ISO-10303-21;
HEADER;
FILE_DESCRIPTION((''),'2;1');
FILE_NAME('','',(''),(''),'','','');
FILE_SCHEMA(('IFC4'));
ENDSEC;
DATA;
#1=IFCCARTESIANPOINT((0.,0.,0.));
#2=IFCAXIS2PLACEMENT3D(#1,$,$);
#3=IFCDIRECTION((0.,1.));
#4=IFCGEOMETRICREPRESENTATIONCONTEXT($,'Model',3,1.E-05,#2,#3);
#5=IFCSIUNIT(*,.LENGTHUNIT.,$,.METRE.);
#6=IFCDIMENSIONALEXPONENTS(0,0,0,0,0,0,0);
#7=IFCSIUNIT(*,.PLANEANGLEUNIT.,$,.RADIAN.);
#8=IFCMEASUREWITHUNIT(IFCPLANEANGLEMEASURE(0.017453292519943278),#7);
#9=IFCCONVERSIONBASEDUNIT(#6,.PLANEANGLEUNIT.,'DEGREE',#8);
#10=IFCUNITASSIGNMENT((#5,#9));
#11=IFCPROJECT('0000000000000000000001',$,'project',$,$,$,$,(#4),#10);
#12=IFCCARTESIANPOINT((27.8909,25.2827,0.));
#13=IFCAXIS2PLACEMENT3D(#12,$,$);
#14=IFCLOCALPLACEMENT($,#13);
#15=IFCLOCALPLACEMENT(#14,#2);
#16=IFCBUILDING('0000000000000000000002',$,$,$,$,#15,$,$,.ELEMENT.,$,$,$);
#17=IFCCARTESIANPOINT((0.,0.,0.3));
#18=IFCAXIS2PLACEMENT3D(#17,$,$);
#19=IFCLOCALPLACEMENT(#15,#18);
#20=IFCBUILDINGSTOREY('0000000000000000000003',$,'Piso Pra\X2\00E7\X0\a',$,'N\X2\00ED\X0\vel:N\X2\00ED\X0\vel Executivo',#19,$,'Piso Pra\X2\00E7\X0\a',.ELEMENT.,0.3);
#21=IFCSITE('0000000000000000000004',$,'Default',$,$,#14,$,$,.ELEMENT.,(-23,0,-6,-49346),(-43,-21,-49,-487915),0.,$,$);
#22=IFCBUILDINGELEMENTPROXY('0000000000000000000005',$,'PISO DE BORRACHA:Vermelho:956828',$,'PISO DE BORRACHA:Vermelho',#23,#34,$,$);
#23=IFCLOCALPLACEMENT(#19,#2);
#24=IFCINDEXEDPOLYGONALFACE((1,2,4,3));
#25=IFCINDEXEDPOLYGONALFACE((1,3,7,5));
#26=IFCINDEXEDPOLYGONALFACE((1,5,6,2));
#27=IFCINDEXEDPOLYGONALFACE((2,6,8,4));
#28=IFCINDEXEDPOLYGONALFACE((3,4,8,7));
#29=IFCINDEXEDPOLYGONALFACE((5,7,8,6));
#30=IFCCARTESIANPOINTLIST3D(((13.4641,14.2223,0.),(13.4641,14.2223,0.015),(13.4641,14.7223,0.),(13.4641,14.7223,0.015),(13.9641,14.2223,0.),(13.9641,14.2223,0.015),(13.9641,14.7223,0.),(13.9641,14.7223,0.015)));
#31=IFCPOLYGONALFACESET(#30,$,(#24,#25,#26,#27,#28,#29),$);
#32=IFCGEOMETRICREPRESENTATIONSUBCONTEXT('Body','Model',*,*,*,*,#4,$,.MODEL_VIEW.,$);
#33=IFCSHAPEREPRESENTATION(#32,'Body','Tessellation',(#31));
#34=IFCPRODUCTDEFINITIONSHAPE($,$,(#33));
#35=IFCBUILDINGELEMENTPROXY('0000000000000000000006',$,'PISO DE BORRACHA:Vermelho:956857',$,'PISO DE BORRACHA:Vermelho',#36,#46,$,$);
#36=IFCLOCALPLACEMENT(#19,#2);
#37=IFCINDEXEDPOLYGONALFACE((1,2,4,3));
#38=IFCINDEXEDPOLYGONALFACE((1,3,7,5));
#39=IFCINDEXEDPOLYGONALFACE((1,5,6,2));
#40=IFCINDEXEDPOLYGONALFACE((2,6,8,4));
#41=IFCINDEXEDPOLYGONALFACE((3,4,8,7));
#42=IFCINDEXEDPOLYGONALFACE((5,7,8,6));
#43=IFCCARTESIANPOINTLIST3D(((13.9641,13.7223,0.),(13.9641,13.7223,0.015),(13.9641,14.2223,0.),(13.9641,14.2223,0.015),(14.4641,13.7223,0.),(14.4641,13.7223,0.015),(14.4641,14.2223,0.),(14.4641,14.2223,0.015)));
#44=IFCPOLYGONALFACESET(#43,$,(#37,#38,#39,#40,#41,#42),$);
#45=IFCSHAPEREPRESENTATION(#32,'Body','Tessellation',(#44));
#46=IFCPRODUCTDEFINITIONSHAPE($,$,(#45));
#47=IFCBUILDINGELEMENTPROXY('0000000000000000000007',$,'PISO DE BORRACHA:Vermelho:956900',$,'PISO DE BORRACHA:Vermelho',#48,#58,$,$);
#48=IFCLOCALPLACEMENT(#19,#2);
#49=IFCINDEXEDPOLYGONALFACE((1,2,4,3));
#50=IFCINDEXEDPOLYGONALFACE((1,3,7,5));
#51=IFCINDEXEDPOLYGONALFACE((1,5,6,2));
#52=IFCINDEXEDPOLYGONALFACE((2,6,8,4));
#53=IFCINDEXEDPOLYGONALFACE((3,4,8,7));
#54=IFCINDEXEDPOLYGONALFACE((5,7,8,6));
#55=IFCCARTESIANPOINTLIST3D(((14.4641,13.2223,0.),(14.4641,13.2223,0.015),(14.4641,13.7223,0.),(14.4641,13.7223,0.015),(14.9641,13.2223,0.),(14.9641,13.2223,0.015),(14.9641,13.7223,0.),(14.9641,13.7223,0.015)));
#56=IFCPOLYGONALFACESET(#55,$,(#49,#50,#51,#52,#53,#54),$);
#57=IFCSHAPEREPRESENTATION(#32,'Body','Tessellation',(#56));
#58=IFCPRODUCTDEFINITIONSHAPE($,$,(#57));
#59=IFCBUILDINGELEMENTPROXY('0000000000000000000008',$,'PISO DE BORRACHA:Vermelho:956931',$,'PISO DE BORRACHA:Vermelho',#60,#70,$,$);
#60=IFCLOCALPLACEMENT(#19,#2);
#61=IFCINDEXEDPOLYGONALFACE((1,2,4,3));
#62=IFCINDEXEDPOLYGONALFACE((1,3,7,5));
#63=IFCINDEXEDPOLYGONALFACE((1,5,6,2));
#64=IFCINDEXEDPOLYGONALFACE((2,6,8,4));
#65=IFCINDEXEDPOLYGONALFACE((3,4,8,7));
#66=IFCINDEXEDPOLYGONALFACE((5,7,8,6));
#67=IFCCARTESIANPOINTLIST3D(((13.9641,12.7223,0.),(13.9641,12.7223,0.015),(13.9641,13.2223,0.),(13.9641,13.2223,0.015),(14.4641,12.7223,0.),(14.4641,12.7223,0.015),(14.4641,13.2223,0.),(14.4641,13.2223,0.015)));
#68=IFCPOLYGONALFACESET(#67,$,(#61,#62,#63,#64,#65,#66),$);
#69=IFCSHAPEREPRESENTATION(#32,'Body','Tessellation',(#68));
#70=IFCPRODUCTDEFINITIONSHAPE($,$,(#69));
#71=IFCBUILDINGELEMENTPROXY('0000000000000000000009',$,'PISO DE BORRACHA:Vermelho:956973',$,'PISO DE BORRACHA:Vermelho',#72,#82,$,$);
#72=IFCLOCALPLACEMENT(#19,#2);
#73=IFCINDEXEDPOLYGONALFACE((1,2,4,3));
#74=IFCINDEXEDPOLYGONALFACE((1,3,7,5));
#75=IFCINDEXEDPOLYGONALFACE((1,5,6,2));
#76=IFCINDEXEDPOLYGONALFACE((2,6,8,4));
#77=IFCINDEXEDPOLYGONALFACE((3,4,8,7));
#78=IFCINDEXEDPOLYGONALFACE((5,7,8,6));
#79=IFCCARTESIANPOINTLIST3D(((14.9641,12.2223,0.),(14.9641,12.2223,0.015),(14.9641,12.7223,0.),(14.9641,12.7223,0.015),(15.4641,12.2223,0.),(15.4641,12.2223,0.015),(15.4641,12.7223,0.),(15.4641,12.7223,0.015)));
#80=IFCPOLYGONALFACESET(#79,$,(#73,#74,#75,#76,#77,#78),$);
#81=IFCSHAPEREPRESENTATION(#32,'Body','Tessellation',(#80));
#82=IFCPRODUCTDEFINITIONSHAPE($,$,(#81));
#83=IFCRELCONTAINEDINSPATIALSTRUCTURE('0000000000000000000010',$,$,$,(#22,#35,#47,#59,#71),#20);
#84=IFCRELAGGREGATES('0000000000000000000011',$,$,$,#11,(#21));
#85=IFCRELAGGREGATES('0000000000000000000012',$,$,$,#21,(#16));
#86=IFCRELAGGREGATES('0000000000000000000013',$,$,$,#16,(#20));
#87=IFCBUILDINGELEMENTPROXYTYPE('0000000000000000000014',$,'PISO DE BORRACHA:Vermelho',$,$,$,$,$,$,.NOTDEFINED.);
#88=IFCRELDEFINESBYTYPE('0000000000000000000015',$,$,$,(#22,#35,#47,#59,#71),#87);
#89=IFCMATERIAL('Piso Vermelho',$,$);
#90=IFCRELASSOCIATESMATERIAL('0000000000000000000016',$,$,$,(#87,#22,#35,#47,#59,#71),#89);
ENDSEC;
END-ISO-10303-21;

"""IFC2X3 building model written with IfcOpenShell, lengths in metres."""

from ifc_helpers import new_model, entity, si_unit, converted_unit, direction, frame, origin, origin_2d_with_axis, place, context, subcontext, project, spatial, rectangle, extrude, source, transform, mapped, material, type_object, type_shapes, element, save


model = new_model("IFC2X3")

# Units and contexts
model_context = context("Model", 3, precision=1e-05, world=origin(), true_north=direction((0.0, 1.0)))
body_context = subcontext(model_context, "Body", "Model", "MODEL_VIEW")
ifc_project = project(units=[si_unit("LENGTHUNIT", "METRE"), converted_unit("PLANEANGLEUNIT", "DEGREE", entity("IfcPlaneAngleMeasure", 0.017453292519943278), si_unit("PLANEANGLEUNIT", "RADIAN"), dimensions=[0, 0, 0, 0, 0, 0, 0])], contexts=[model_context])

# Site, building, storey
site_placement = place(None, frame((27.8909, 25.2827, 0.0)))
site = spatial("IfcSite", under=ifc_project, at=site_placement, Name="Default", CompositionType="ELEMENT", RefLatitude=(-23, 0, -6, -49346), RefLongitude=(-43, -21, -49, -487915), RefElevation=0.0)
building_placement = place(site_placement, origin())
building = spatial("IfcBuilding", under=site, at=building_placement, CompositionType="ELEMENT")
storey_placement = place(building_placement, frame((0.0, 0.0, 0.3)))
storey = spatial("IfcBuildingStorey", under=building, at=storey_placement, Name="Piso Praça", ObjectType="Nível:Nível Executivo", LongName="Piso Praça", CompositionType="ELEMENT", Elevation=0.3)

# Building element proxies
ifc_material_1 = material(Name="Piso Vermelho")
building_element_proxy_type_1 = type_object("IfcBuildingElementProxyType", Name="PISO DE BORRACHA:Vermelho", PredefinedType="NOTDEFINED", material=ifc_material_1)
shared_shape_1 = source(origin(), body_context, "Body", "SweptSolid", [
    extrude(rectangle(XDim=0.5, YDim=0.5, at=origin_2d_with_axis()), frame((0.25, 0.25, 0.0), z_axis=(0.0, 0.0, 1.0), x_axis=(-1.0, 0.0, 0.0)), (0.0, 0.0, 1.0), 0.015),
])
type_shapes(building_element_proxy_type_1, [shared_shape_1])
for number, where, name in (
    (1, (13.4641, 14.2223, 0.0), "PISO DE BORRACHA:Vermelho:956828"),
    (2, (13.9641, 13.7223, 0.0), "PISO DE BORRACHA:Vermelho:956857"),
    (3, (14.4641, 13.2223, 0.0), "PISO DE BORRACHA:Vermelho:956900"),
    (4, (13.9641, 12.7223, 0.0), "PISO DE BORRACHA:Vermelho:956931"),
    (5, (14.9641, 12.2223, 0.0), "PISO DE BORRACHA:Vermelho:956973"),
):
    element("IfcBuildingElementProxy", number, at=place(storey_placement, frame(where)), inside=storey, type_object=building_element_proxy_type_1, material=ifc_material_1, Name=name, ObjectType="PISO DE BORRACHA:Vermelho", context=body_context, shape_type="MappedRepresentation", body=[
        mapped(shared_shape_1, transform((0.0, 0.0, 0.0), scale=1.0)),
    ])

save(model, "model.ifc")
